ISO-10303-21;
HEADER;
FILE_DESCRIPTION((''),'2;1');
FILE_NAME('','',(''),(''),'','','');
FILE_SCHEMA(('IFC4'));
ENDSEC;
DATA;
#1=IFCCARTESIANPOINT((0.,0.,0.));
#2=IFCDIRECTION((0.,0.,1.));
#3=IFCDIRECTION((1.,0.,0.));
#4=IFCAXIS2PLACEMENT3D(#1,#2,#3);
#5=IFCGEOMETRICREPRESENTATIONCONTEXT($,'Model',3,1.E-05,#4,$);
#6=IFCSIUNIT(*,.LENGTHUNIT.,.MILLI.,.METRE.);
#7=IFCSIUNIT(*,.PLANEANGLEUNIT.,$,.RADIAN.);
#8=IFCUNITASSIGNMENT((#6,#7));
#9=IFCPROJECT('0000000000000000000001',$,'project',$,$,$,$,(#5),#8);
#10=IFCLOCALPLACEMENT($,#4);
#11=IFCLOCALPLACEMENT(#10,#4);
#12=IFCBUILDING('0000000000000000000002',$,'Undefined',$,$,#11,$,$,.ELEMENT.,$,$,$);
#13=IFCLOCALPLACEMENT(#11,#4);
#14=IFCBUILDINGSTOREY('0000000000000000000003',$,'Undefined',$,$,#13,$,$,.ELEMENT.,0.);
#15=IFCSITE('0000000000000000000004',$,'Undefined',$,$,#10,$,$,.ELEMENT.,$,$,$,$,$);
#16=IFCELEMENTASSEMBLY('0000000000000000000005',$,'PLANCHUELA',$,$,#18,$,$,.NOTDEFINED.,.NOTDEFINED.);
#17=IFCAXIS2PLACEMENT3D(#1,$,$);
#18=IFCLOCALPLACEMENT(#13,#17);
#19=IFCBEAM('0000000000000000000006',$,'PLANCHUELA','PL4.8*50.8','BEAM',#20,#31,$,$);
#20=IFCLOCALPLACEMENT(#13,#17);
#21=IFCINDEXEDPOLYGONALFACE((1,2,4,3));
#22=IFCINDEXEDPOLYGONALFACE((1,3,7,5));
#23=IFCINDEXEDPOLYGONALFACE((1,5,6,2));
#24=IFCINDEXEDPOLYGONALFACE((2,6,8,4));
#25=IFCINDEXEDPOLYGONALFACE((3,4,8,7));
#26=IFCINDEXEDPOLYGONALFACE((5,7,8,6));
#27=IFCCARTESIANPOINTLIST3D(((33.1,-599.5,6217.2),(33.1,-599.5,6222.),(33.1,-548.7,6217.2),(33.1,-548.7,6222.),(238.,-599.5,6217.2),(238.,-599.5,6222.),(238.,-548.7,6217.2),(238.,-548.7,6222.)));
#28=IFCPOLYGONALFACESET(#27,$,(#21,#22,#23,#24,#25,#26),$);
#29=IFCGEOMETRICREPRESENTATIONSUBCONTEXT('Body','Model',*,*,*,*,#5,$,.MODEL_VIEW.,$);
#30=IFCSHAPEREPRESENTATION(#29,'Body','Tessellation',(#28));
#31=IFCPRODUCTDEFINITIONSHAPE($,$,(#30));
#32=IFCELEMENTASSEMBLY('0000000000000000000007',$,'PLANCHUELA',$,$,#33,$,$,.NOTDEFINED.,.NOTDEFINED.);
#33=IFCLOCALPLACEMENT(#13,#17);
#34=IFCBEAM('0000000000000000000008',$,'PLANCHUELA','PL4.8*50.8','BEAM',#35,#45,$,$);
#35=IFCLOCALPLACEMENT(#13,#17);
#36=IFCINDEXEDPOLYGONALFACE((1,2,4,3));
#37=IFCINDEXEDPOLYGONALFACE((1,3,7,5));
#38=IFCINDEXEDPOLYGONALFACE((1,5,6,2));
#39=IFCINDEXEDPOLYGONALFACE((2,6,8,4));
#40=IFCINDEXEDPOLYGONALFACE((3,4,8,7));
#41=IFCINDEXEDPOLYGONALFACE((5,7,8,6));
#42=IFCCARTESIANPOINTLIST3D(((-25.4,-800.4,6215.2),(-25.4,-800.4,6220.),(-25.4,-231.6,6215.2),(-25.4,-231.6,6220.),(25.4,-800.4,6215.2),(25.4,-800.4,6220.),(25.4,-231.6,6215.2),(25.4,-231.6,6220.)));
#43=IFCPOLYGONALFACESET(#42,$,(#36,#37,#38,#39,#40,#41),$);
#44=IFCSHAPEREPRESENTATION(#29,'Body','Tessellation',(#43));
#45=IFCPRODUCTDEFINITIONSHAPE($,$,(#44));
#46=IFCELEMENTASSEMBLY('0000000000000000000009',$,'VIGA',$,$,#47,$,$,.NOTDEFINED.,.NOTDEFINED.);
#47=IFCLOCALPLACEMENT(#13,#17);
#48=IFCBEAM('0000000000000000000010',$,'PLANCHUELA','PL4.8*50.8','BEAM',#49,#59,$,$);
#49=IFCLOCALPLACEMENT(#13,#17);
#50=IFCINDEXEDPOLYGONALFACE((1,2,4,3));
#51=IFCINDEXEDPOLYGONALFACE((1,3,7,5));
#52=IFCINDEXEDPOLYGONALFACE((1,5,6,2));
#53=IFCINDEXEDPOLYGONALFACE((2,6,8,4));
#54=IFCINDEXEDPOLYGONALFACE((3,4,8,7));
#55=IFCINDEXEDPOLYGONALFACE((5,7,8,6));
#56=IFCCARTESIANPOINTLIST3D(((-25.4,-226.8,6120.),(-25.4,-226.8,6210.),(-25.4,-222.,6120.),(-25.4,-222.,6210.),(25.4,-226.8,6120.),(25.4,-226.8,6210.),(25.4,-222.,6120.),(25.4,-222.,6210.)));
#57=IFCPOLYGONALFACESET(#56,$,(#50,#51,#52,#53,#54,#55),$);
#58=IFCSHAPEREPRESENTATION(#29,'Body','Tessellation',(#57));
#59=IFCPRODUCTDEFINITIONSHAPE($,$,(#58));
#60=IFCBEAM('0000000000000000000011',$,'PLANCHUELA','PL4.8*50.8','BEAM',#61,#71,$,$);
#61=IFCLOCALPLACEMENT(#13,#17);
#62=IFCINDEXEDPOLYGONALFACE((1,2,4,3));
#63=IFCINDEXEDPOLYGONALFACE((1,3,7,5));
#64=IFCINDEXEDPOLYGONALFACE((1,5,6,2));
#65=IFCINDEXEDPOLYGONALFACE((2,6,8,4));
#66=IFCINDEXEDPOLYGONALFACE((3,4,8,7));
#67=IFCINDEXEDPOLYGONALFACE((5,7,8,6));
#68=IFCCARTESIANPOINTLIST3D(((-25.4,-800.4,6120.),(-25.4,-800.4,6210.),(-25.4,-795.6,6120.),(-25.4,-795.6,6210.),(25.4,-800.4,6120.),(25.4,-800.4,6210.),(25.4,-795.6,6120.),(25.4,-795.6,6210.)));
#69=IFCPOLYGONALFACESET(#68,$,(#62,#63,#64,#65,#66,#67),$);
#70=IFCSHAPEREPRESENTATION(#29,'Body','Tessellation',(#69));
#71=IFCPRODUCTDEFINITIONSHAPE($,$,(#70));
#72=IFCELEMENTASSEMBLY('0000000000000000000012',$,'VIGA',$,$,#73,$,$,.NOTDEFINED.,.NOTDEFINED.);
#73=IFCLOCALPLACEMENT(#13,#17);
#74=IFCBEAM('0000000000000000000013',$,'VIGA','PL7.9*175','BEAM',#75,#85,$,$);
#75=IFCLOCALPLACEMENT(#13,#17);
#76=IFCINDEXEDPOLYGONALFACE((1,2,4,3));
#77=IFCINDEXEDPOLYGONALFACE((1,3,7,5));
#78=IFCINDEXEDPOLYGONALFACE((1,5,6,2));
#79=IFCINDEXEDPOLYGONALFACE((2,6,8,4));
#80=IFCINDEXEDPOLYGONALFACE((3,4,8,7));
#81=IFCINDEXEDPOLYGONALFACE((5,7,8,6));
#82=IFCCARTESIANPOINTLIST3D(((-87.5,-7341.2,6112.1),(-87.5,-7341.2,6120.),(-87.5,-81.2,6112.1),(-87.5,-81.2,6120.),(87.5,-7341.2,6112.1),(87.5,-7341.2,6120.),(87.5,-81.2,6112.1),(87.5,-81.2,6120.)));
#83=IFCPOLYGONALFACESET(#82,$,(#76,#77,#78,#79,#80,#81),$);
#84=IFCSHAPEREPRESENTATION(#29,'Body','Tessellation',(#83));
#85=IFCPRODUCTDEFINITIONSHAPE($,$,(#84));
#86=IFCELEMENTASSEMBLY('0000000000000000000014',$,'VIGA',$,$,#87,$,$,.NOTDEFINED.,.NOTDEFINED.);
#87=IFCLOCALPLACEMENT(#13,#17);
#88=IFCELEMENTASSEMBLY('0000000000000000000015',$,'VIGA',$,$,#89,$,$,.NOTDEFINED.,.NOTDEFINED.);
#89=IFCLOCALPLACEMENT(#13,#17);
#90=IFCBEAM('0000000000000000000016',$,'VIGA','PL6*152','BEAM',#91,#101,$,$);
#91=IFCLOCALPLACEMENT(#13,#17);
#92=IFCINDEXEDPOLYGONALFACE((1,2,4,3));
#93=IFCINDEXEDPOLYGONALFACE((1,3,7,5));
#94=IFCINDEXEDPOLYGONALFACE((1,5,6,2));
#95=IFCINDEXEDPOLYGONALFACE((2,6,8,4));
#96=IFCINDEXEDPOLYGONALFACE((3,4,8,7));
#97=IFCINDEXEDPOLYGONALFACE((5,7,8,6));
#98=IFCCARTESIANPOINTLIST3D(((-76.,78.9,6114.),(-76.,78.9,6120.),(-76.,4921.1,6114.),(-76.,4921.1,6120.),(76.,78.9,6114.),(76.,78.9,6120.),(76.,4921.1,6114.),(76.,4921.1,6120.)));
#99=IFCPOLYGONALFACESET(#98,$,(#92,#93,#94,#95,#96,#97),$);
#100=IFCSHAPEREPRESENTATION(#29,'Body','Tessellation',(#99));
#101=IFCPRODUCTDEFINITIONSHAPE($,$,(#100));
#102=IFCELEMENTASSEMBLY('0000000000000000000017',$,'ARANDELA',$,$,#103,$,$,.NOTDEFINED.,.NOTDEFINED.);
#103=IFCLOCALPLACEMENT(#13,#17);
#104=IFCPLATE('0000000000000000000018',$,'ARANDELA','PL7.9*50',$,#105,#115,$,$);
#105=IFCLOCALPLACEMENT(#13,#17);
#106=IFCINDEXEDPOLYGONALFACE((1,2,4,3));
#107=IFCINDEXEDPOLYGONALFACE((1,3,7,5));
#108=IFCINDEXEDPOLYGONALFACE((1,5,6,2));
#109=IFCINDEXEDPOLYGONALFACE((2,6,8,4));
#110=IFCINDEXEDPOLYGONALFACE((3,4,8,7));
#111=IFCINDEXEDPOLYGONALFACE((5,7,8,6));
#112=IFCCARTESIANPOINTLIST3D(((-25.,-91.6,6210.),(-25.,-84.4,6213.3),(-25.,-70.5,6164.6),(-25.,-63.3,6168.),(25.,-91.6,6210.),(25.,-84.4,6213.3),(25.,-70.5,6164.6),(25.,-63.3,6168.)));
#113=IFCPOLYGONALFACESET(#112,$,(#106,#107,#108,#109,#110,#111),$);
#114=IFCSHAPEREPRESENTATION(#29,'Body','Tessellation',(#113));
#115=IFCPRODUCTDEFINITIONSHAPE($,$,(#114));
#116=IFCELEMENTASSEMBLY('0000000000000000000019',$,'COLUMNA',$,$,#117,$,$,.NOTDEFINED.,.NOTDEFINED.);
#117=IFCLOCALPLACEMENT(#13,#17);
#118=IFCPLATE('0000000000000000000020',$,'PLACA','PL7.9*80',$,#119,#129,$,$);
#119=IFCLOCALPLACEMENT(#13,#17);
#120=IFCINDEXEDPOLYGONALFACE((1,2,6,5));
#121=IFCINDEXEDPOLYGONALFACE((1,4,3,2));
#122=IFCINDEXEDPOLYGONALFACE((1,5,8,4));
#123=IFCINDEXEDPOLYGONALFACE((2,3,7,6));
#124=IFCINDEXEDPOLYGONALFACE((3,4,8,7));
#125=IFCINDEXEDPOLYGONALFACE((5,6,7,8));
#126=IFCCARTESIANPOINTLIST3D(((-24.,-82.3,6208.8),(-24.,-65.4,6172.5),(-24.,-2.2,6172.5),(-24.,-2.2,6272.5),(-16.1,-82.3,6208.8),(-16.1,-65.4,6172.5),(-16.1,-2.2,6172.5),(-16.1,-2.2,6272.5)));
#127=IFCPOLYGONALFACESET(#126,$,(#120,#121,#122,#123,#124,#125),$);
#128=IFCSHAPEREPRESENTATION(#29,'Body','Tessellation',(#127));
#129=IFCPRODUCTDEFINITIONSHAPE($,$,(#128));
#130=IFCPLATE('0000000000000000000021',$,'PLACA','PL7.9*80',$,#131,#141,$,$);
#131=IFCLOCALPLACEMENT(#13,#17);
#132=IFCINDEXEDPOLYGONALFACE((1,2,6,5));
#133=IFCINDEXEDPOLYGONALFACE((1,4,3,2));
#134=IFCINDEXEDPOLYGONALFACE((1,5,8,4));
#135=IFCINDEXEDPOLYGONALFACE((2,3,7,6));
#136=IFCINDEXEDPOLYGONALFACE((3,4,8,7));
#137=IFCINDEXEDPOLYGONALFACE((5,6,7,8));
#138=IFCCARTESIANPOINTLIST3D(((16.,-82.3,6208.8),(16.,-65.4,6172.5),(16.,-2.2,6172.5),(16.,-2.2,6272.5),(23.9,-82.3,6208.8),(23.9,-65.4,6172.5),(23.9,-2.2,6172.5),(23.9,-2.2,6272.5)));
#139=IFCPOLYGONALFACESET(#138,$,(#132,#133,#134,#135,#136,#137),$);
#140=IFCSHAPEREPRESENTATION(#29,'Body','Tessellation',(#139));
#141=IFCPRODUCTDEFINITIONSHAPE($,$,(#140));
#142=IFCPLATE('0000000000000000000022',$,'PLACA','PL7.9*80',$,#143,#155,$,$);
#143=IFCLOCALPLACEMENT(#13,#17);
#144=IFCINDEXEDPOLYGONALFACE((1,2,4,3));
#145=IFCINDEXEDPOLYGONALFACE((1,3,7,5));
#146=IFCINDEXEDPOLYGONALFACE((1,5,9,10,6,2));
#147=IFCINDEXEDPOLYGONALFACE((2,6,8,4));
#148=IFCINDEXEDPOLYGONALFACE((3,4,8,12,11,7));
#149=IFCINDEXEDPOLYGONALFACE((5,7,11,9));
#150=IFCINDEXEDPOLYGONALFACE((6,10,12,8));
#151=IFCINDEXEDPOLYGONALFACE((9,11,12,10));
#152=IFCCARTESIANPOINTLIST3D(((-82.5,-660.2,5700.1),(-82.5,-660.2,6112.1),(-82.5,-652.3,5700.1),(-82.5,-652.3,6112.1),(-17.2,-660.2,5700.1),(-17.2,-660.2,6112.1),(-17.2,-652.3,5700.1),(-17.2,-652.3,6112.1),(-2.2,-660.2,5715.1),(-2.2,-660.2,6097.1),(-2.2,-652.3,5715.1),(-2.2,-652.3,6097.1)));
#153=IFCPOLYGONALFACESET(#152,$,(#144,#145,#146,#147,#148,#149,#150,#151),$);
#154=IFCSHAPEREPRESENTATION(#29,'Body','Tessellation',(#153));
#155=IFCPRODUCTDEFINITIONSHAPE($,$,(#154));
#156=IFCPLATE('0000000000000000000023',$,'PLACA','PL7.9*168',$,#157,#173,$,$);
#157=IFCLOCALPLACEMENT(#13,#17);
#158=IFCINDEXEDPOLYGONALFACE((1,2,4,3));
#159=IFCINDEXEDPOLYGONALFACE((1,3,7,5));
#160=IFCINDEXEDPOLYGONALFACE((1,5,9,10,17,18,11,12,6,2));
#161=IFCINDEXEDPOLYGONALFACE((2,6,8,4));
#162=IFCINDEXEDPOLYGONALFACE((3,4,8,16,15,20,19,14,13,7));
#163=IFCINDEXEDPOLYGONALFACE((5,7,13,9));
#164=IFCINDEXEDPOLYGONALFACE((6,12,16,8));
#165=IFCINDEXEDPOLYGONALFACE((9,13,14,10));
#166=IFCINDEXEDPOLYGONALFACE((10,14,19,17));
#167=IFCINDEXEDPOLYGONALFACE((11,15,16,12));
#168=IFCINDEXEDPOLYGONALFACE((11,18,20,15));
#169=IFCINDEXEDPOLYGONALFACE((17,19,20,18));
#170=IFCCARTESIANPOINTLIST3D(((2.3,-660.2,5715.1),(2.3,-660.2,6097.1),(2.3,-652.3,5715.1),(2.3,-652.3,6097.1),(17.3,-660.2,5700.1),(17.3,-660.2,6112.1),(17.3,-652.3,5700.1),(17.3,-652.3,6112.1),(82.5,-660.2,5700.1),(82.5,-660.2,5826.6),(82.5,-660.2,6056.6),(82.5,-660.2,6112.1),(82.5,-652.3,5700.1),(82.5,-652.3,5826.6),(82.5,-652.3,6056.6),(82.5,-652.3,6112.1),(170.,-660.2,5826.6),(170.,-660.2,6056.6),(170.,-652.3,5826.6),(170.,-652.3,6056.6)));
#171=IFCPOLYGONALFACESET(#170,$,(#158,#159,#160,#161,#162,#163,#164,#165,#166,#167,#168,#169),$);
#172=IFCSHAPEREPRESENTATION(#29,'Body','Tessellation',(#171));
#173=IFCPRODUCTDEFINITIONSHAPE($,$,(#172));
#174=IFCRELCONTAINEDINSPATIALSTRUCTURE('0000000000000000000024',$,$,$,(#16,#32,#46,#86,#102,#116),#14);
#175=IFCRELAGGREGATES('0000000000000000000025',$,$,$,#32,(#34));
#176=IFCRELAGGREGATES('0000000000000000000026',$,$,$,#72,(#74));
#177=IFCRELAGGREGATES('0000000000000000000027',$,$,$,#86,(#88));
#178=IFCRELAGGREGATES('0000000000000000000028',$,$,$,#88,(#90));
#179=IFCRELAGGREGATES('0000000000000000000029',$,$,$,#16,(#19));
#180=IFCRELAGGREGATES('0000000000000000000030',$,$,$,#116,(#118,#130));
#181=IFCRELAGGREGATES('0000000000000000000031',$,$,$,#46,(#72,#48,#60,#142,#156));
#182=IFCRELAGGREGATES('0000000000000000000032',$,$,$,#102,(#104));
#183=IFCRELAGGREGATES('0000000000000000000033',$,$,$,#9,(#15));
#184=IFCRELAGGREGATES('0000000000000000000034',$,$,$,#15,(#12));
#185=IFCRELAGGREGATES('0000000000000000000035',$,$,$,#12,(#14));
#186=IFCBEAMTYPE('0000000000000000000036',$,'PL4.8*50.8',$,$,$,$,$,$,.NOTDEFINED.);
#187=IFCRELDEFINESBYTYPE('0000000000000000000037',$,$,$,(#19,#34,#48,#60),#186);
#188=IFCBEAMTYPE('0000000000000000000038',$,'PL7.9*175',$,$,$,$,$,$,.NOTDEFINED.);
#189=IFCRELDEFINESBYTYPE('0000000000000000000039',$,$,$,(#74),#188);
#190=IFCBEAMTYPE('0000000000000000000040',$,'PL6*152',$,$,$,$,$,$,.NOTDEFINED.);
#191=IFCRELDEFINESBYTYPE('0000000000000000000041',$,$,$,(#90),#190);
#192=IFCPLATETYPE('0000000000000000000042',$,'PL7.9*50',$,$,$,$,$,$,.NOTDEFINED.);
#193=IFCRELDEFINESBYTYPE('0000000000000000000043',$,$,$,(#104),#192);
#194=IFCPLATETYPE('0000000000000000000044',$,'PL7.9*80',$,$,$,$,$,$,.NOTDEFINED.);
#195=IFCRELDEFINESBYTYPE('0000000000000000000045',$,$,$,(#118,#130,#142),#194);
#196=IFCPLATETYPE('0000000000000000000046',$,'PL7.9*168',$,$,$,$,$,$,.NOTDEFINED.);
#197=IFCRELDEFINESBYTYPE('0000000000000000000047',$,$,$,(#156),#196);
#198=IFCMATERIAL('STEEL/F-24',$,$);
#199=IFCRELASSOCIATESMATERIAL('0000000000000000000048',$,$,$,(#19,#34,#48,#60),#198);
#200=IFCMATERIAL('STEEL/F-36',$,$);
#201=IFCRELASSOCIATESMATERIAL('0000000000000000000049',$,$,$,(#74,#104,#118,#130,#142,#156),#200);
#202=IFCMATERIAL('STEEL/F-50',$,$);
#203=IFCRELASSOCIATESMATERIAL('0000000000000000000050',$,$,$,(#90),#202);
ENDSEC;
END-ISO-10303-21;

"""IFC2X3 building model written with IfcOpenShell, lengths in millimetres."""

from ifc_helpers import new_model, si_unit, frame, origin_with_axes, origin_2d_with_axis, place, context, subcontext, project, spatial, polyline, rectangle, outline, extrude, material, type_object, element, aggregate, save


model = new_model("IFC2X3")

# Units and contexts
model_context = context("Model", 3, precision=1e-05, world=origin_with_axes())
body_context = subcontext(model_context, "Body", "Model", "MODEL_VIEW")
ifc_project = project(units=[si_unit("LENGTHUNIT", "METRE", prefix="MILLI"), si_unit("PLANEANGLEUNIT", "RADIAN")], contexts=[model_context])

# Site, building, storey
site_placement = place(None, origin_with_axes())
site = spatial("IfcSite", under=ifc_project, at=site_placement, Name="Undefined", CompositionType="ELEMENT")
building_placement = place(site_placement, origin_with_axes())
building = spatial("IfcBuilding", under=site, at=building_placement, Name="Undefined", CompositionType="ELEMENT")
storey_placement = place(building_placement, origin_with_axes())
storey = spatial("IfcBuildingStorey", under=building, at=storey_placement, Name="Undefined", CompositionType="ELEMENT", Elevation=0.0)

# Element assemblies, beams
assembly_1_placement = place(storey_placement, origin_with_axes())
assembly_1 = element("IfcElementAssembly", 1, at=assembly_1_placement, inside=storey, Name="PLANCHUELA", AssemblyPlace="NOTDEFINED", PredefinedType="NOTDEFINED")
ifc_material_1 = material(Name="STEEL/F-24")
beam_type_1 = type_object("IfcBeamType", Name="PL4.8*50.8", PredefinedType="NOTDEFINED")
beam_1_placement = place(assembly_1_placement, frame((238.0, -574.1, 6219.6), z_axis=(0.0, -1.0, 0.0), x_axis=(-1.0, 0.0, 0.0)))
beam_1 = element("IfcBeam", 2, at=beam_1_placement, type_object=beam_type_1, material=ifc_material_1, Name="PLANCHUELA", Description="PL4.8*50.8", ObjectType="BEAM", context=body_context, shape_type="SweptSolid", body=[
    extrude(rectangle(XDim=4.8, YDim=50.8, at=origin_2d_with_axis()), frame((204.9, 0.0, 0.0), z_axis=(-1.0, 0.0, 0.0), x_axis=(0.0, -1.0, 0.0)), (0.0, 0.0, 1.0), 204.9),
])
assembly_2_placement = place(storey_placement, origin_with_axes())
assembly_2 = element("IfcElementAssembly", 3, at=assembly_2_placement, inside=storey, Name="PLANCHUELA", AssemblyPlace="NOTDEFINED", PredefinedType="NOTDEFINED")
beam_2_placement = place(assembly_2_placement, frame((0.0, -800.4, 6217.6), z_axis=(1.0, 0.0, 0.0), x_axis=(0.0, 1.0, 0.0)))
beam_2 = element("IfcBeam", 4, at=beam_2_placement, type_object=beam_type_1, material=ifc_material_1, Name="PLANCHUELA", Description="PL4.8*50.8", ObjectType="BEAM", context=body_context, shape_type="SweptSolid", body=[
    extrude(rectangle(XDim=4.8, YDim=50.8, at=origin_2d_with_axis()), frame((568.8, 0.0, 0.0), z_axis=(-1.0, 0.0, 0.0), x_axis=(0.0, -1.0, 0.0)), (0.0, 0.0, 1.0), 568.8),
])
aggregate(assembly_2, [beam_2])

# Element assemblies, beams
assembly_3_placement = place(storey_placement, origin_with_axes())
assembly_3 = element("IfcElementAssembly", 5, at=assembly_3_placement, inside=storey, Name="VIGA", AssemblyPlace="NOTDEFINED", PredefinedType="NOTDEFINED")
beam_3_placement = place(assembly_3_placement, frame((0.0, -224.4, 6210.0), z_axis=(-1.0, 0.0, 0.0), x_axis=(0.0, 0.0, -1.0)))
beam_3 = element("IfcBeam", 6, at=beam_3_placement, type_object=beam_type_1, material=ifc_material_1, Name="PLANCHUELA", Description="PL4.8*50.8", ObjectType="BEAM", context=body_context, shape_type="SweptSolid", body=[
    extrude(rectangle(XDim=4.8, YDim=50.8, at=origin_2d_with_axis()), frame((90.0, 0.0, 0.0), z_axis=(-1.0, 0.0, 0.0), x_axis=(0.0, -1.0, 0.0)), (0.0, 0.0, 1.0), 90.0),
])
beam_4_placement = place(assembly_3_placement, frame((0.0, -798.0, 6210.0), z_axis=(-1.0, 0.0, 0.0), x_axis=(0.0, 0.0, -1.0)))
beam_4 = element("IfcBeam", 7, at=beam_4_placement, type_object=beam_type_1, material=ifc_material_1, Name="PLANCHUELA", Description="PL4.8*50.8", ObjectType="BEAM", context=body_context, shape_type="SweptSolid", body=[
    extrude(rectangle(XDim=4.8, YDim=50.8, at=origin_2d_with_axis()), frame((90.0, 0.0, 0.0), z_axis=(-1.0, 0.0, 0.0), x_axis=(0.0, -1.0, 0.0)), (0.0, 0.0, 1.0), 90.0),
])
assembly_4_placement = place(assembly_3_placement, origin_with_axes())
assembly_4 = element("IfcElementAssembly", 8, at=assembly_4_placement, Name="VIGA", AssemblyPlace="NOTDEFINED", PredefinedType="NOTDEFINED")
ifc_material_2 = material(Name="STEEL/F-36")
beam_type_2 = type_object("IfcBeamType", Name="PL7.9*175", PredefinedType="NOTDEFINED")
beam_5_placement = place(assembly_4_placement, frame((0.0, -81.2, 6116.0), z_axis=(1.0, 0.0, -0.000007), x_axis=(0.0, -1.0, 0.0)))
beam_5 = element("IfcBeam", 9, at=beam_5_placement, type_object=beam_type_2, material=ifc_material_2, Name="VIGA", Description="PL7.9*175", ObjectType="BEAM", context=body_context, shape_type="SweptSolid", body=[
    extrude(rectangle(XDim=7.9, YDim=175.0, at=origin_2d_with_axis()), frame((7260.0, 0.0, 0.0), z_axis=(-1.0, 0.0, 0.0), x_axis=(0.0, -1.0, 0.0)), (0.0, 0.0, 1.0), 7260.0),
])
aggregate(assembly_4, [beam_5])

# Element assemblies, beam
assembly_5_placement = place(storey_placement, origin_with_axes())
assembly_5 = element("IfcElementAssembly", 10, at=assembly_5_placement, inside=storey, Name="VIGA", AssemblyPlace="NOTDEFINED", PredefinedType="NOTDEFINED")
assembly_6_placement = place(assembly_5_placement, origin_with_axes())
assembly_6 = element("IfcElementAssembly", 11, at=assembly_6_placement, Name="VIGA", AssemblyPlace="NOTDEFINED", PredefinedType="NOTDEFINED")
aggregate(assembly_5, [assembly_6])
ifc_material_3 = material(Name="STEEL/F-50")
beam_type_3 = type_object("IfcBeamType", Name="PL6*152", PredefinedType="NOTDEFINED")
beam_6_placement = place(assembly_6_placement, frame((0.0, 78.9, 6117.0), z_axis=(-1.0, 0.000001, 0.0), x_axis=(0.000001, 1.0, 0.0)))
beam_6 = element("IfcBeam", 12, at=beam_6_placement, type_object=beam_type_3, material=ifc_material_3, Name="VIGA", Description="PL6*152", ObjectType="BEAM", context=body_context, shape_type="SweptSolid", body=[
    extrude(rectangle(XDim=6.0, YDim=152.0, at=origin_2d_with_axis()), frame((4842.3, 0.0, 0.0), z_axis=(-1.0, 0.0, 0.0), x_axis=(0.0, -1.0, 0.0)), (0.0, 0.0, 1.0), 4842.3),
])
aggregate(assembly_6, [beam_6])

# Element assembly, plate
assembly_7_placement = place(storey_placement, origin_with_axes())
assembly_7 = element("IfcElementAssembly", 13, at=assembly_7_placement, inside=storey, Name="ARANDELA", AssemblyPlace="NOTDEFINED", PredefinedType="NOTDEFINED")
plate_type_1 = type_object("IfcPlateType", Name="PL7.9*50", PredefinedType="NOTDEFINED")
plate_1_placement = place(assembly_7_placement, frame((25.0, -88.0, 6211.7), z_axis=(0.000001, 0.90676, 0.421646), x_axis=(0.000001, 0.421646, -0.90676)))
plate_1 = element("IfcPlate", 14, at=plate_1_placement, type_object=plate_type_1, material=ifc_material_2, Name="ARANDELA", Description="PL7.9*50", context=body_context, shape_type="SweptSolid", body=[
    extrude(outline(polyline([(0.0, 0.0), (50.0, 0.0), (50.0, 50.0), (0.0, 50.0), (0.0, 0.0)])), frame((0.0, 0.0, -4.0), z_axis=(0.0, 0.0, 1.0), x_axis=(1.0, 0.0, 0.0)), (0.0, 0.0, 1.0), 7.9),
])

# Element assembly, plates
assembly_8_placement = place(storey_placement, origin_with_axes())
assembly_8 = element("IfcElementAssembly", 15, at=assembly_8_placement, inside=storey, Name="COLUMNA", AssemblyPlace="NOTDEFINED", PredefinedType="NOTDEFINED")
plate_type_2 = type_object("IfcPlateType", Name="PL7.9*80", PredefinedType="NOTDEFINED")
plate_2_placement = place(assembly_8_placement, frame((-20.0, -2.2, 6172.5), z_axis=(-1.0, -0.000002, -0.000004), x_axis=(0.000002, -1.0, -0.000001)))
plate_2 = element("IfcPlate", 16, at=plate_2_placement, type_object=plate_type_2, material=ifc_material_2, Name="PLACA", Description="PL7.9*80", context=body_context, shape_type="SweptSolid", body=[
    extrude(outline(polyline([(0.0, 0.0), (63.2, 0.0), (80.1, 36.3), (0.0, 100.0), (0.0, 0.0)])), frame((0.0, 0.0, -4.0), z_axis=(0.0, 0.0, 1.0), x_axis=(1.0, 0.0, 0.0)), (0.0, 0.0, 1.0), 7.9),
])
plate_3_placement = place(assembly_8_placement, frame((20.0, -2.2, 6172.5), z_axis=(-1.0, 0.000001, 0.0), x_axis=(-0.000001, -1.0, -0.000001)))
plate_3 = element("IfcPlate", 17, at=plate_3_placement, type_object=plate_type_2, material=ifc_material_2, Name="PLACA", Description="PL7.9*80", context=body_context, shape_type="SweptSolid", body=[
    extrude(outline(polyline([(0.0, 0.0), (63.2, 0.0), (80.1, 36.3), (0.0, 100.0), (0.0, 0.0)])), frame((0.0, 0.0, -4.0), z_axis=(0.0, 0.0, 1.0), x_axis=(1.0, 0.0, 0.0)), (0.0, 0.0, 1.0), 7.9),
])

# Plates
plate_4_placement = place(assembly_3_placement, frame((-2.2, -656.2, 6112.1), z_axis=(0.0, -1.0, 0.0), x_axis=(-1.0, 0.0, -0.000007)))
plate_4 = element("IfcPlate", 18, at=plate_4_placement, type_object=plate_type_2, material=ifc_material_2, Name="PLACA", Description="PL7.9*80", context=body_context, shape_type="SweptSolid", body=[
    extrude(outline(polyline([(0.0, 15.0), (15.0, 0.0), (80.2, 0.0), (80.3, 412.0), (15.0, 412.0), (0.0, 397.0), (0.0, 15.0)])), frame((0.0, 0.0, -4.0), z_axis=(0.0, 0.0, 1.0), x_axis=(1.0, 0.0, 0.0)), (0.0, 0.0, 1.0), 7.9),
])
plate_type_3 = type_object("IfcPlateType", Name="PL7.9*168", PredefinedType="NOTDEFINED")
plate_5_placement = place(assembly_3_placement, frame((2.3, -656.2, 6112.1), z_axis=(0.0, 1.0, 0.0), x_axis=(1.0, 0.0, -0.000007)))
plate_5 = element("IfcPlate", 19, at=plate_5_placement, type_object=plate_type_3, material=ifc_material_2, Name="PLACA", Description="PL7.9*168", context=body_context, shape_type="SweptSolid", body=[
    extrude(outline(polyline([(0.0, 15.0), (15.0, 0.0), (80.2, 0.0), (80.3, 55.5), (167.8, 55.5), (167.8, 285.5), (80.3, 285.5), (80.3, 412.0), (15.0, 412.0), (0.0, 397.0), (0.0, 15.0)])), frame((0.0, 0.0, -4.0), z_axis=(0.0, 0.0, 1.0), x_axis=(1.0, 0.0, 0.0)), (0.0, 0.0, 1.0), 7.9),
])

aggregate(assembly_1, [beam_1])

aggregate(assembly_8, [plate_2, plate_3])

aggregate(assembly_3, [assembly_4, beam_3, beam_4, plate_4, plate_5])
aggregate(assembly_7, [plate_1])

save(model, "model.ifc")
